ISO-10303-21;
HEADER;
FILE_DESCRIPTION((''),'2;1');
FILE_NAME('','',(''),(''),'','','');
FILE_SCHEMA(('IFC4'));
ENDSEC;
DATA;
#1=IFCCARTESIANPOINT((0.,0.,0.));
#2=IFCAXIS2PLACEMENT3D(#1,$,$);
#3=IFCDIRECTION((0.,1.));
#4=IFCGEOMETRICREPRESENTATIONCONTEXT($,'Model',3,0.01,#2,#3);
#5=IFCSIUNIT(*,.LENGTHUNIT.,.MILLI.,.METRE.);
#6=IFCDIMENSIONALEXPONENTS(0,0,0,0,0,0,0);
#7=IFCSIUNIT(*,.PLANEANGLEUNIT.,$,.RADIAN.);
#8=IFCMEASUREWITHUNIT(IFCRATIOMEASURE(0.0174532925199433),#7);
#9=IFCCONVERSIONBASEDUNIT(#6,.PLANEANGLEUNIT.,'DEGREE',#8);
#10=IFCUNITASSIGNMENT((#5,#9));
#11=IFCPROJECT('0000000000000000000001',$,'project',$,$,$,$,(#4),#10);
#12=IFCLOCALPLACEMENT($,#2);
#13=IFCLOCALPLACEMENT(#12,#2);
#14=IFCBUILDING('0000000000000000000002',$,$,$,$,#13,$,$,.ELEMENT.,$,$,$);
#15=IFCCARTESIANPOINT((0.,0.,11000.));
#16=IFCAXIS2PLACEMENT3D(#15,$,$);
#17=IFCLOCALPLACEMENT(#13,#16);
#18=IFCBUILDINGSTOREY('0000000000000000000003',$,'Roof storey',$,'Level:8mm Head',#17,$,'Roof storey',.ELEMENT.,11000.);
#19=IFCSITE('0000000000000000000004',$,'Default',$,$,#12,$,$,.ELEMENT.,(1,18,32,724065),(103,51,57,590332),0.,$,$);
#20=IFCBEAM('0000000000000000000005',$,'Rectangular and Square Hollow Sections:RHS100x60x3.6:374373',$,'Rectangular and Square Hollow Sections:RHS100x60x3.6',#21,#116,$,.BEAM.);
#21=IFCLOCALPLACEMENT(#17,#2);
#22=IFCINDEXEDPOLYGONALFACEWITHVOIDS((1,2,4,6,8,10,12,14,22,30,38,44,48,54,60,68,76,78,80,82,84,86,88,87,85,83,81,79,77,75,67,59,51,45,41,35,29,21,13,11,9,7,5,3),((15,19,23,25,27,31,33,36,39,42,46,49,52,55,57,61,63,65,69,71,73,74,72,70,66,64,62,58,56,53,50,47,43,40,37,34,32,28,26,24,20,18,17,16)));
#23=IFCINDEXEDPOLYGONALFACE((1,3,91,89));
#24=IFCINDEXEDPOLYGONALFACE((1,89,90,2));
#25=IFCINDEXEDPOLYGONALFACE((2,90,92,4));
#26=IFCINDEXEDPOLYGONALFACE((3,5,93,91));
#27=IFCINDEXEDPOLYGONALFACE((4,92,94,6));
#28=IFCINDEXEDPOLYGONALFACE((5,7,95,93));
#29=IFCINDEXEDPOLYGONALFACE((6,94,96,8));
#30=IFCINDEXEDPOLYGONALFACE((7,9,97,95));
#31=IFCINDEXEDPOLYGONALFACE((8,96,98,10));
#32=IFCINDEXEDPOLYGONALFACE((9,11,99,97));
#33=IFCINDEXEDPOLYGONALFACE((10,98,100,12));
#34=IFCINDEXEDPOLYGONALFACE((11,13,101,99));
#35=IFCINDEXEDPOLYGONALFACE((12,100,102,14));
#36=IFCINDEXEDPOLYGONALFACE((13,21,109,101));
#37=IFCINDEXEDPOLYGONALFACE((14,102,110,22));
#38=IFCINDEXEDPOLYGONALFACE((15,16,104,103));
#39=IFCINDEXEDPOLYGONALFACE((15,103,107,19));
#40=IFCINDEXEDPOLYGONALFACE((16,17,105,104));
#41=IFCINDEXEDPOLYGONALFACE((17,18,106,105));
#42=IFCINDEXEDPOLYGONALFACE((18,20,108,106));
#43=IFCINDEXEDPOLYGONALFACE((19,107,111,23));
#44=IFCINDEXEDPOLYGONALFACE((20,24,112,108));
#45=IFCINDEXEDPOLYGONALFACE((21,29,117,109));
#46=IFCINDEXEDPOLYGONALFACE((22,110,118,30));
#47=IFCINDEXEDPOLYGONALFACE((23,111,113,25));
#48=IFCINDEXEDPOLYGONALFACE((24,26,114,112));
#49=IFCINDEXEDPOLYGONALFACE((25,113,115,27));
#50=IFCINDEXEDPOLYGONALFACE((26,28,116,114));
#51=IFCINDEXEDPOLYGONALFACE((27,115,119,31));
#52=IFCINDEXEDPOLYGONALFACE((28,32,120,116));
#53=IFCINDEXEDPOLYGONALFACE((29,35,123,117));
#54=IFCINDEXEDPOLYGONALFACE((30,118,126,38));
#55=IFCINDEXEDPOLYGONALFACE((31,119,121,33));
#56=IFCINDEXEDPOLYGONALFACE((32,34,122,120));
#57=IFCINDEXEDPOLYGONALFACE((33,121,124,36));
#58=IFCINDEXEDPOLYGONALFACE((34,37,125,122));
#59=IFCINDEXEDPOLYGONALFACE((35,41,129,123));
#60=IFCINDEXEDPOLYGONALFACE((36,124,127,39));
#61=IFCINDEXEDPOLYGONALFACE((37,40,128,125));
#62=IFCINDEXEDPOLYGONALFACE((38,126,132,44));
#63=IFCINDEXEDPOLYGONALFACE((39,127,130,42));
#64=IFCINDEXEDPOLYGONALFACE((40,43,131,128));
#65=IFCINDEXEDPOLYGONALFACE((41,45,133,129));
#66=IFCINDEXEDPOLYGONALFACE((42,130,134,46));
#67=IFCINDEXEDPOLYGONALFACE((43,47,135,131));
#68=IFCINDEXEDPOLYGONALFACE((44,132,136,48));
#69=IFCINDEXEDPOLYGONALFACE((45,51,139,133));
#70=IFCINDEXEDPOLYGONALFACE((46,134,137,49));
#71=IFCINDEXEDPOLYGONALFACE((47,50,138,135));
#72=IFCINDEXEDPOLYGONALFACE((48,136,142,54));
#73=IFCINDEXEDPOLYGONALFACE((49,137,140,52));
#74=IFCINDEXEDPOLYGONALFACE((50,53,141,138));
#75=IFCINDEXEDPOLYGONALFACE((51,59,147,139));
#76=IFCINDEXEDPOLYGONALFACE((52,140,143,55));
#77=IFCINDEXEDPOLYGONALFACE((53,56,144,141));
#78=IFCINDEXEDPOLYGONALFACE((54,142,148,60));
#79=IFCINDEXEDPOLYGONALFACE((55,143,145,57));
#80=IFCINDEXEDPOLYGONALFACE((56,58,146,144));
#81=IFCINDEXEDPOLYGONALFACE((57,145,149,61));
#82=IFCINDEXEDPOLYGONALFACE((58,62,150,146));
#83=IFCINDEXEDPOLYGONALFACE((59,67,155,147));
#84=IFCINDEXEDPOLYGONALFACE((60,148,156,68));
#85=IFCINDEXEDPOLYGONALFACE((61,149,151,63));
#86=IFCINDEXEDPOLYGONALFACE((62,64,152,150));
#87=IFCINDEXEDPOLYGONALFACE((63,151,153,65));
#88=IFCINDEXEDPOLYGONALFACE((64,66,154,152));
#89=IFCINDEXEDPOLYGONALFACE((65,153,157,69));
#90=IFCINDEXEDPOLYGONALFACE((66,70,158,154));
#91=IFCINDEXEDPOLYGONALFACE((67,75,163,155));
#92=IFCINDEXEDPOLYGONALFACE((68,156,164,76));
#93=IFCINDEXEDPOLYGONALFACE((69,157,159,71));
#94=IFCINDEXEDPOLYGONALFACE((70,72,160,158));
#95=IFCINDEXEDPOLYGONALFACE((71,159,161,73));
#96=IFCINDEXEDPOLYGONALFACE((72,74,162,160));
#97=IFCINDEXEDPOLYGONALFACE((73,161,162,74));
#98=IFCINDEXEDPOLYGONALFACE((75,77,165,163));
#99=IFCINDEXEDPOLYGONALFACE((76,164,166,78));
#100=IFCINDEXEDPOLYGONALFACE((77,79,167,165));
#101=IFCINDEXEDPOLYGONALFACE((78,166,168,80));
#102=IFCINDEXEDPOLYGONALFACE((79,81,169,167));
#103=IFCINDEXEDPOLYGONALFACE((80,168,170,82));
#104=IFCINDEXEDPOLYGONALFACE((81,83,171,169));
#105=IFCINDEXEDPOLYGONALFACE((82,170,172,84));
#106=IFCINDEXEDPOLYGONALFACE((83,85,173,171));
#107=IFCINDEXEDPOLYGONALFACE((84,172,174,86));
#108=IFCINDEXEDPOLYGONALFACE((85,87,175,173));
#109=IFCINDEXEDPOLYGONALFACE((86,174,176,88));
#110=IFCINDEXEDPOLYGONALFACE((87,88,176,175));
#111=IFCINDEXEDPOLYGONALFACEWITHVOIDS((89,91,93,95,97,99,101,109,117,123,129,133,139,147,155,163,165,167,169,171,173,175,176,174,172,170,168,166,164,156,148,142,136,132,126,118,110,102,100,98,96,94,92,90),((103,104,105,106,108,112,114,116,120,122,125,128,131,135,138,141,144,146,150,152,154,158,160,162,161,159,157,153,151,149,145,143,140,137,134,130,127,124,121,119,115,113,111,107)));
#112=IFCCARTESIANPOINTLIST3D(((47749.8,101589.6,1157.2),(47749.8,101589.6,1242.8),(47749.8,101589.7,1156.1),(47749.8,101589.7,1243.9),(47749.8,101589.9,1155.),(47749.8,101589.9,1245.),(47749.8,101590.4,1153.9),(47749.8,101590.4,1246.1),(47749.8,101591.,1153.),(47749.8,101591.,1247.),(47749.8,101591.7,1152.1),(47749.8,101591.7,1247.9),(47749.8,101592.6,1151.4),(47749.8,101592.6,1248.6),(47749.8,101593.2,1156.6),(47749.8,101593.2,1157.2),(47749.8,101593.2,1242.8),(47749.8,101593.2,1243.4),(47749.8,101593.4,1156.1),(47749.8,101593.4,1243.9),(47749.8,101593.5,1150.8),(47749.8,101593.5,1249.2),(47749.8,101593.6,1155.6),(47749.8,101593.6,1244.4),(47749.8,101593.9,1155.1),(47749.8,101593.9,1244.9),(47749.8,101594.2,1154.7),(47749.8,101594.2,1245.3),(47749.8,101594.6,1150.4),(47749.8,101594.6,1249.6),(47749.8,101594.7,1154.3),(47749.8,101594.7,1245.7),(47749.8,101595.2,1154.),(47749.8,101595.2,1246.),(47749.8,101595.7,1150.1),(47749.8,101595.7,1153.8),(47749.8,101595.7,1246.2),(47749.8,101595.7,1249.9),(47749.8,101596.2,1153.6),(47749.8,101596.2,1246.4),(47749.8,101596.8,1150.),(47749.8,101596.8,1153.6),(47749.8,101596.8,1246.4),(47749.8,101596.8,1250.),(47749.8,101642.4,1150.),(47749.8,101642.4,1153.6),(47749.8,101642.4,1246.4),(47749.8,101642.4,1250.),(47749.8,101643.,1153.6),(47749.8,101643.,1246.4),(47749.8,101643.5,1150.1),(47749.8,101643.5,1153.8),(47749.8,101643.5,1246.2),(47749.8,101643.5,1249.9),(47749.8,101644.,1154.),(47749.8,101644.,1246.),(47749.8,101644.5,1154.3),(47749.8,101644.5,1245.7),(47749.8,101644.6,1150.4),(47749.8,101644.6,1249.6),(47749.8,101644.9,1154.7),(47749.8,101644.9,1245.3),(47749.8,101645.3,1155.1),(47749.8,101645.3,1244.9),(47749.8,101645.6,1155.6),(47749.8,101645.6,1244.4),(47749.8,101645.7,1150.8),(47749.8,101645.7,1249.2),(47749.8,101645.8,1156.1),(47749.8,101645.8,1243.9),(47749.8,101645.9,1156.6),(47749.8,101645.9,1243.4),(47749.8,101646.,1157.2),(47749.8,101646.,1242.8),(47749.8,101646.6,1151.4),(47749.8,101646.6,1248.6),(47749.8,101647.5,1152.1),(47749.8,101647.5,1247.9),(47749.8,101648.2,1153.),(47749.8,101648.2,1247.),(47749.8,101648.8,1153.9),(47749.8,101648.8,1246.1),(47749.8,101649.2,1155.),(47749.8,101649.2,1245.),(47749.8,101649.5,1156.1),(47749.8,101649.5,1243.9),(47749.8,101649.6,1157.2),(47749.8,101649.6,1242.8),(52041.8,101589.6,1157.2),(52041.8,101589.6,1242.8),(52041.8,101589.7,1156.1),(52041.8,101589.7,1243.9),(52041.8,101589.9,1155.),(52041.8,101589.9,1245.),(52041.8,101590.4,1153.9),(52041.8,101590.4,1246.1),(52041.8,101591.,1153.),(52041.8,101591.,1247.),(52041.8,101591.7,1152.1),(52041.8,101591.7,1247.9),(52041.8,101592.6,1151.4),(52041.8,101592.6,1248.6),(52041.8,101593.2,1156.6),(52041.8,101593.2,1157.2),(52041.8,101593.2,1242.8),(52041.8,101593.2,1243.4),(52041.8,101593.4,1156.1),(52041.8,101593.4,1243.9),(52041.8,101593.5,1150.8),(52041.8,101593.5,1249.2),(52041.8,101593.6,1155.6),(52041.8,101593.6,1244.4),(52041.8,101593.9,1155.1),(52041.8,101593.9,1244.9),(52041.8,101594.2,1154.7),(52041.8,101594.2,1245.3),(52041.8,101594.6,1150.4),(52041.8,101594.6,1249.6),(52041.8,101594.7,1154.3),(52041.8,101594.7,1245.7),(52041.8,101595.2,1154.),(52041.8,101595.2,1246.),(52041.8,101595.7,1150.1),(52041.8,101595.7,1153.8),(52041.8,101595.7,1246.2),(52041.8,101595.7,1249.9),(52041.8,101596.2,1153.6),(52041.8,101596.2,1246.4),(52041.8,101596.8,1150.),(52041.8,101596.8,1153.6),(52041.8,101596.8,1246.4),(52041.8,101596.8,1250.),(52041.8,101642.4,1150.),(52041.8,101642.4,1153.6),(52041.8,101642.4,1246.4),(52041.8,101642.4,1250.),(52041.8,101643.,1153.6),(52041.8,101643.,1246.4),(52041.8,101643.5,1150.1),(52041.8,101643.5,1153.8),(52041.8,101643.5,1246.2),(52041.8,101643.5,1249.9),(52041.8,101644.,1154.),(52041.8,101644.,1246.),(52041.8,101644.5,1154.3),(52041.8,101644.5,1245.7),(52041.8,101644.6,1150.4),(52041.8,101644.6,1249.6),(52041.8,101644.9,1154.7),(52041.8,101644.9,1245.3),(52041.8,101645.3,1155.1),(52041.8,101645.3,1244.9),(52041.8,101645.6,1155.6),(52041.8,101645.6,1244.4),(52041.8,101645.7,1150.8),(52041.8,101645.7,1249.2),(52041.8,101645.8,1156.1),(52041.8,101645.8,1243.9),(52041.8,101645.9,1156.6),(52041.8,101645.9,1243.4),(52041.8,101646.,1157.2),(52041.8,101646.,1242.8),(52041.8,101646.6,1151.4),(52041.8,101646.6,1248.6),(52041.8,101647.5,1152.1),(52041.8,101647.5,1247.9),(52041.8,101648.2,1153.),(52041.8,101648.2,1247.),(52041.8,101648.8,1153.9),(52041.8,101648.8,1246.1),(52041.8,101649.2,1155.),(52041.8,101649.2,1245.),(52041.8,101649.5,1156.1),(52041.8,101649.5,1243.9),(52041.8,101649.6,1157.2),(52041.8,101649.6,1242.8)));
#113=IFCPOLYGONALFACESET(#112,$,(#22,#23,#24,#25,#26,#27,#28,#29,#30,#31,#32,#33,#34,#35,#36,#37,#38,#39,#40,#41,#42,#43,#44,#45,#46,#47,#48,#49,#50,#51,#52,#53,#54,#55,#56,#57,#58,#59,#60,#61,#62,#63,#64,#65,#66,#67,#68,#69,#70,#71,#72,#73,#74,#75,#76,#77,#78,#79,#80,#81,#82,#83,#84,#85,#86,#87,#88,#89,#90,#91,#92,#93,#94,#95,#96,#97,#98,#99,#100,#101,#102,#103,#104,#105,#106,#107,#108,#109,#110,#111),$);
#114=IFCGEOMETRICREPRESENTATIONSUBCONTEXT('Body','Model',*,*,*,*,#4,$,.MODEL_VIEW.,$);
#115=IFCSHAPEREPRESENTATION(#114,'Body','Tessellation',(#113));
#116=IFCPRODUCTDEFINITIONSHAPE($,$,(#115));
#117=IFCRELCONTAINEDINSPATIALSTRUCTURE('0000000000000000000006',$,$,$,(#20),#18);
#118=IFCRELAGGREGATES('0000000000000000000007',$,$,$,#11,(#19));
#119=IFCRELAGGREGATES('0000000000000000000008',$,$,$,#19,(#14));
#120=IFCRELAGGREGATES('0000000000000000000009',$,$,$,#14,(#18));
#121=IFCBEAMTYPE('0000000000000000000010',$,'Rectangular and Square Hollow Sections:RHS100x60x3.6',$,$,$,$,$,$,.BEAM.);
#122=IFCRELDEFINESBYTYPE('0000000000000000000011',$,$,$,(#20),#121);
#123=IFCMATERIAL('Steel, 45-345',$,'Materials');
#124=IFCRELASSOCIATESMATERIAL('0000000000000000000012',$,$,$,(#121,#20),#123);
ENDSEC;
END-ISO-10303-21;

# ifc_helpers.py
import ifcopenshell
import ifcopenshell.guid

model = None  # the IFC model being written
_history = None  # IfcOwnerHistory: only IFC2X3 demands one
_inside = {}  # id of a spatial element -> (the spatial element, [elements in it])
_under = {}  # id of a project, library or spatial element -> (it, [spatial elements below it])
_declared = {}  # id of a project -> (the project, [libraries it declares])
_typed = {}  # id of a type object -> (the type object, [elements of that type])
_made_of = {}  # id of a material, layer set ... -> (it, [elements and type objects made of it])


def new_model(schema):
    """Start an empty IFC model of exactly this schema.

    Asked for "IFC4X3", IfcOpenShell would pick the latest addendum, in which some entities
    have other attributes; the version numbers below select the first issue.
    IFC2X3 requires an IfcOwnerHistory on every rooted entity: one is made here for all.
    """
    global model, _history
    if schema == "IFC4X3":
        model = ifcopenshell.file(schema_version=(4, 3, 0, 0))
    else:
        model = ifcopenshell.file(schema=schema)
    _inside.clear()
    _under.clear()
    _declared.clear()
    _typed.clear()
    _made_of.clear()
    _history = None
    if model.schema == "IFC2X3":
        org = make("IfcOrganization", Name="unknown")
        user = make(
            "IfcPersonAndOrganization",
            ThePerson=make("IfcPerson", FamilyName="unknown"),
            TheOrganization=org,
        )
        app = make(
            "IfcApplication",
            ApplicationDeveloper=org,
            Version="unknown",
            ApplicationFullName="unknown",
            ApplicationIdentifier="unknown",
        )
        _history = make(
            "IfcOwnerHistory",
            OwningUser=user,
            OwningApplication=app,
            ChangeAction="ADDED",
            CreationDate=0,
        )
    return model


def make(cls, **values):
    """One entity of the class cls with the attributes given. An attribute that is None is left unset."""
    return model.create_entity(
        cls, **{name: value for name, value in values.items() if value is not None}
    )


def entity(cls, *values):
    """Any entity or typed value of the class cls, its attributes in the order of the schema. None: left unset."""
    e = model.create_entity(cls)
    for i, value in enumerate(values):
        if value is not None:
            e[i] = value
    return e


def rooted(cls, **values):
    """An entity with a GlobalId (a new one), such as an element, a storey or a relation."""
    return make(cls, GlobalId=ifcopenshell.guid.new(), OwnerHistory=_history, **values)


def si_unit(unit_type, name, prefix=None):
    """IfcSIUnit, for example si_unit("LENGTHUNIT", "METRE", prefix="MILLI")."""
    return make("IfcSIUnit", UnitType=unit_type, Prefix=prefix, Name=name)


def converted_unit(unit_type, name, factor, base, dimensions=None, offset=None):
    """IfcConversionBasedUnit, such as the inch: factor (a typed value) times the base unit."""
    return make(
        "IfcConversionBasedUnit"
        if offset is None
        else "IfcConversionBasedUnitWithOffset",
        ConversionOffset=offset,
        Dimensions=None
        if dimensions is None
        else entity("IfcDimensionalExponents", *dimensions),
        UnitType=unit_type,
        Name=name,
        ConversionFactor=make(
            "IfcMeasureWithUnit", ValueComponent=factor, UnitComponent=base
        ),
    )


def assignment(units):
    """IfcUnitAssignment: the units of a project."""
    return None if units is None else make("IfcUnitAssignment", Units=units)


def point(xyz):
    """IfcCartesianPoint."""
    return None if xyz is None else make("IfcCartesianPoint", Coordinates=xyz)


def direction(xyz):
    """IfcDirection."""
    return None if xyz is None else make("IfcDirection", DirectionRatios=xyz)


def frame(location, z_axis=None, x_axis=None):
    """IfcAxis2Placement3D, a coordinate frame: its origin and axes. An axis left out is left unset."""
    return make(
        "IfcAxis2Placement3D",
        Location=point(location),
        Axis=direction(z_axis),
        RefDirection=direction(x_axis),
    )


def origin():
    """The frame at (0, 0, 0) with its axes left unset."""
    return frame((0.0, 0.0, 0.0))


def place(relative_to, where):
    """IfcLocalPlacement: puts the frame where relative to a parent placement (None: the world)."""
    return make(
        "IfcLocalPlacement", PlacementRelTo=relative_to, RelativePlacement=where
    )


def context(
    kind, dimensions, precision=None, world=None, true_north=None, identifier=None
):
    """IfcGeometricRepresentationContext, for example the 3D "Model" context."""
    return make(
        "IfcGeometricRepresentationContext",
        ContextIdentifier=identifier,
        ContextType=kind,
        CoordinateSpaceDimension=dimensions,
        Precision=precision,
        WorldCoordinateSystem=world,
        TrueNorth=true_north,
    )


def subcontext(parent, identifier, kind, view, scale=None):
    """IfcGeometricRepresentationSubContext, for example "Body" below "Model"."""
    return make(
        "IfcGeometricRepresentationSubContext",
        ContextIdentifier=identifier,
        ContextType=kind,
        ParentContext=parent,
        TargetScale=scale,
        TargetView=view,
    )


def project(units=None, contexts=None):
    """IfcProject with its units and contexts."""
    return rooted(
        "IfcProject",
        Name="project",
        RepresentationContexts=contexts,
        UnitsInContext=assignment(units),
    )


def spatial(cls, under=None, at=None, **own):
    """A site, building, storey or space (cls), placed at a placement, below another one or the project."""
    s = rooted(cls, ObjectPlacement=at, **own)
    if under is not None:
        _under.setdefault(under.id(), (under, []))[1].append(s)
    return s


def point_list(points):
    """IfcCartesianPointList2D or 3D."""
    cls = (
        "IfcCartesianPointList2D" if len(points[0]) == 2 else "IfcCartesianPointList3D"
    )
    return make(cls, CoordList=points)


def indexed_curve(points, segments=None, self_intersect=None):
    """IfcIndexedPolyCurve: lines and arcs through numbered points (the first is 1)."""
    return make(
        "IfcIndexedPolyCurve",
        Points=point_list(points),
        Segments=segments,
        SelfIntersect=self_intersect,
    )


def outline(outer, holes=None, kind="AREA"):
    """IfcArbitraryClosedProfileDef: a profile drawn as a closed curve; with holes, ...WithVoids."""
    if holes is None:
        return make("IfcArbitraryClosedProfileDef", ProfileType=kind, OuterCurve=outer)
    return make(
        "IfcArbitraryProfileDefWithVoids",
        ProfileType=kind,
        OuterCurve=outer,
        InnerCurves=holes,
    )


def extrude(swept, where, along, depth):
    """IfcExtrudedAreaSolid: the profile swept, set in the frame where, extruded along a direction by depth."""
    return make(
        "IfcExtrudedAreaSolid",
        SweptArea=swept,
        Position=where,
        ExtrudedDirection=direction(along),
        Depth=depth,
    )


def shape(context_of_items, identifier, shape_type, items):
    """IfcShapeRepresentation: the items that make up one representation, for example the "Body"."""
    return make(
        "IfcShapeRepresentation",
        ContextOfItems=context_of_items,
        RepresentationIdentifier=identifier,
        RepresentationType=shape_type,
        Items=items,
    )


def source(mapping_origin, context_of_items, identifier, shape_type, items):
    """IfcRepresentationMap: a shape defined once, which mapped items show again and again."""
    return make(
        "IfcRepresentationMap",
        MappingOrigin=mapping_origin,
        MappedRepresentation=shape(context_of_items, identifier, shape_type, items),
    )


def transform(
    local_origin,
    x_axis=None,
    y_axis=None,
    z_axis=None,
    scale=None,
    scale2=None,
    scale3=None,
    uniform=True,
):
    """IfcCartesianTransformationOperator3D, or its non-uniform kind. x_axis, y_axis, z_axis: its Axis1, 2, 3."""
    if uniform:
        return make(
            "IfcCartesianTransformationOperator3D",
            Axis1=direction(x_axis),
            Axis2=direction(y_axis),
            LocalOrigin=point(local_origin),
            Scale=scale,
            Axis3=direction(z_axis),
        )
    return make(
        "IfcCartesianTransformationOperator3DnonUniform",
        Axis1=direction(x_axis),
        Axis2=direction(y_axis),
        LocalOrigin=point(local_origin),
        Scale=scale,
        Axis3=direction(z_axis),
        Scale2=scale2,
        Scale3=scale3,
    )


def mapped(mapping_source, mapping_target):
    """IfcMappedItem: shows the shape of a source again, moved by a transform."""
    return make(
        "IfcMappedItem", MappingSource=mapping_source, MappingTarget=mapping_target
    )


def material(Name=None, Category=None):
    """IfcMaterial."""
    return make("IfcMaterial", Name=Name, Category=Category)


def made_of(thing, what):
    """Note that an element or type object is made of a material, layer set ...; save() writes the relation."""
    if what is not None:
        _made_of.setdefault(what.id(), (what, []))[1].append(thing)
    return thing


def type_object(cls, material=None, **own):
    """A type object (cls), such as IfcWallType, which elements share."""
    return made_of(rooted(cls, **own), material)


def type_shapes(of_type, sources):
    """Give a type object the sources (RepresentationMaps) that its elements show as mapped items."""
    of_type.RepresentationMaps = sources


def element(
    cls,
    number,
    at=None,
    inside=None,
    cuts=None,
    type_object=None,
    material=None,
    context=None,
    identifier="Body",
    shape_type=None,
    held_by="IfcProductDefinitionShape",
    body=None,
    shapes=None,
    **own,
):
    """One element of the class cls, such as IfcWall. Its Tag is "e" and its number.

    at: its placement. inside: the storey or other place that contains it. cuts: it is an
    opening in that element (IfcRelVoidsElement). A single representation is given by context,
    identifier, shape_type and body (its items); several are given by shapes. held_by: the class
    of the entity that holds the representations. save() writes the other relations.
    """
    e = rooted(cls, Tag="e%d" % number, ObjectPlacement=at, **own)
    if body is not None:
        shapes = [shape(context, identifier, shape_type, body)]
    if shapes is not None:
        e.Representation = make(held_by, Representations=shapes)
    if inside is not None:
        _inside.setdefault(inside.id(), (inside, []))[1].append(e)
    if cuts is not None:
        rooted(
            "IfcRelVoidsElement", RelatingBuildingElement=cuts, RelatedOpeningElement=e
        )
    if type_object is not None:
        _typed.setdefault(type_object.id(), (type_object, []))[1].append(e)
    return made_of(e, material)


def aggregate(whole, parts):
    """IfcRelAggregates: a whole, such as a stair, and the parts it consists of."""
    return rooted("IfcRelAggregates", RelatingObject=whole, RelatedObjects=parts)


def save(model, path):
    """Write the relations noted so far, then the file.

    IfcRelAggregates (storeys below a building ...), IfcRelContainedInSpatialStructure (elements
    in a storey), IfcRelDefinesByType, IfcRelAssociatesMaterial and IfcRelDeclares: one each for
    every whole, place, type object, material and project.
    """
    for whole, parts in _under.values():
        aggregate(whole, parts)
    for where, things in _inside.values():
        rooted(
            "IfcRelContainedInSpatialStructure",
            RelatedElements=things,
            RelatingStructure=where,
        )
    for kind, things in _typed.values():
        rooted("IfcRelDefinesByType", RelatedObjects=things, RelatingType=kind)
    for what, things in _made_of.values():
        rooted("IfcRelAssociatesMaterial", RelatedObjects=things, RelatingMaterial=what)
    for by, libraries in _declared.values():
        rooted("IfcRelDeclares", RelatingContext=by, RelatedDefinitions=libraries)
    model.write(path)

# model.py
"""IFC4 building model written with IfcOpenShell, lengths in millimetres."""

from ifc_helpers import new_model, entity, si_unit, converted_unit, direction, frame, origin, place, context, subcontext, project, spatial, indexed_curve, outline, extrude, source, transform, mapped, material, type_object, type_shapes, element, save


model = new_model("IFC4")

# Units and contexts
model_context = context("Model", 3, precision=0.01, world=origin(), true_north=direction((0.0, 1.0)))
body_context = subcontext(model_context, "Body", "Model", "MODEL_VIEW")
ifc_project = project(units=[si_unit("LENGTHUNIT", "METRE", prefix="MILLI"), converted_unit("PLANEANGLEUNIT", "DEGREE", entity("IfcRatioMeasure", 0.0174532925199433), si_unit("PLANEANGLEUNIT", "RADIAN"), dimensions=[0, 0, 0, 0, 0, 0, 0])], contexts=[model_context])

# Site, building, storey
site_placement = place(None, origin())
site = spatial("IfcSite", under=ifc_project, at=site_placement, Name="Default", CompositionType="ELEMENT", RefLatitude=(1, 18, 32, 724065), RefLongitude=(103, 51, 57, 590332), RefElevation=0.0)
building_placement = place(site_placement, origin())
building = spatial("IfcBuilding", under=site, at=building_placement, CompositionType="ELEMENT")
storey_placement = place(building_placement, frame((0.0, 0.0, 11000.0)))
storey = spatial("IfcBuildingStorey", under=building, at=storey_placement, Name="Roof storey", ObjectType="Level:8mm Head", LongName="Roof storey", CompositionType="ELEMENT", Elevation=11000.0)

# Shared definitions
ifc_material = material(Name="Steel, 45-345", Category="Materials")

# Beam
beam_type_1 = type_object("IfcBeamType", Name="Rectangular and Square Hollow Sections:RHS100x60x3.6", PredefinedType="BEAM", material=ifc_material)
shared_shape_1 = source(origin(), body_context, "Body", "SweptSolid", [
    extrude(outline(indexed_curve([(-30.0, -42.8), (-29.9, -43.9), (-29.6, -45.0), (-29.2, -46.1), (-28.6, -47.0), (-27.9, -47.9), (-27.0, -48.6), (-26.1, -49.2), (-25.0, -49.6), (-23.9, -49.9), (-22.8, -50.0), (22.8, -50.0), (23.9, -49.9), (25.0, -49.6), (26.1, -49.2), (27.0, -48.6), (27.9, -47.9), (28.6, -47.0), (29.2, -46.1), (29.6, -45.0), (29.9, -43.9), (30.0, -42.8), (30.0, 42.8), (29.9, 43.9), (29.6, 45.0), (29.2, 46.1), (28.6, 47.0), (27.9, 47.9), (27.0, 48.6), (26.1, 49.2), (25.0, 49.6), (23.9, 49.9), (22.8, 50.0), (-22.8, 50.0), (-23.9, 49.9), (-25.0, 49.6), (-26.1, 49.2), (-27.0, 48.6), (-27.9, 47.9), (-28.6, 47.0), (-29.2, 46.1), (-29.6, 45.0), (-29.9, 43.9), (-30.0, 42.8), (-30.0, -42.8)], self_intersect=False), holes=[indexed_curve([(22.8, -46.4), (-22.8, -46.4), (-23.4, -46.4), (-23.9, -46.2), (-24.4, -46.0), (-24.9, -45.7), (-25.3, -45.3), (-25.7, -44.9), (-26.0, -44.4), (-26.2, -43.9), (-26.4, -43.4), (-26.4, -42.8), (-26.4, 42.8), (-26.4, 43.4), (-26.2, 43.9), (-26.0, 44.4), (-25.7, 44.9), (-25.3, 45.3), (-24.9, 45.7), (-24.4, 46.0), (-23.9, 46.2), (-23.4, 46.4), (-22.8, 46.4), (22.8, 46.4), (23.4, 46.4), (23.9, 46.2), (24.4, 46.0), (24.9, 45.7), (25.3, 45.3), (25.7, 44.9), (26.0, 44.4), (26.2, 43.9), (26.4, 43.4), (26.4, 42.8), (26.4, -42.8), (26.4, -43.4), (26.2, -43.9), (26.0, -44.4), (25.7, -44.9), (25.3, -45.3), (24.9, -45.7), (24.4, -46.0), (23.9, -46.2), (23.4, -46.4), (22.8, -46.4)], self_intersect=False)]), frame((-2139.5, 0.0, 0.0), z_axis=(1.0, 0.0, 0.0), x_axis=(0.0, -1.0, 0.0)), (0.0, 0.0, 1.0), 4292.0),
])
type_shapes(beam_type_1, [shared_shape_1])
for number, where, name in (
    (1, (49889.3, 101619.6, 1200.0), "Rectangular and Square Hollow Sections:RHS100x60x3.6:374373"),
):
    element("IfcBeam", number, at=place(storey_placement, frame(where)), inside=storey, type_object=beam_type_1, material=ifc_material, Name=name, ObjectType="Rectangular and Square Hollow Sections:RHS100x60x3.6", PredefinedType="BEAM", context=body_context, shape_type="MappedRepresentation", body=[
        mapped(shared_shape_1, transform((0.0, 0.0, 0.0), scale=1.0)),
    ])

save(model, "model.ifc")
